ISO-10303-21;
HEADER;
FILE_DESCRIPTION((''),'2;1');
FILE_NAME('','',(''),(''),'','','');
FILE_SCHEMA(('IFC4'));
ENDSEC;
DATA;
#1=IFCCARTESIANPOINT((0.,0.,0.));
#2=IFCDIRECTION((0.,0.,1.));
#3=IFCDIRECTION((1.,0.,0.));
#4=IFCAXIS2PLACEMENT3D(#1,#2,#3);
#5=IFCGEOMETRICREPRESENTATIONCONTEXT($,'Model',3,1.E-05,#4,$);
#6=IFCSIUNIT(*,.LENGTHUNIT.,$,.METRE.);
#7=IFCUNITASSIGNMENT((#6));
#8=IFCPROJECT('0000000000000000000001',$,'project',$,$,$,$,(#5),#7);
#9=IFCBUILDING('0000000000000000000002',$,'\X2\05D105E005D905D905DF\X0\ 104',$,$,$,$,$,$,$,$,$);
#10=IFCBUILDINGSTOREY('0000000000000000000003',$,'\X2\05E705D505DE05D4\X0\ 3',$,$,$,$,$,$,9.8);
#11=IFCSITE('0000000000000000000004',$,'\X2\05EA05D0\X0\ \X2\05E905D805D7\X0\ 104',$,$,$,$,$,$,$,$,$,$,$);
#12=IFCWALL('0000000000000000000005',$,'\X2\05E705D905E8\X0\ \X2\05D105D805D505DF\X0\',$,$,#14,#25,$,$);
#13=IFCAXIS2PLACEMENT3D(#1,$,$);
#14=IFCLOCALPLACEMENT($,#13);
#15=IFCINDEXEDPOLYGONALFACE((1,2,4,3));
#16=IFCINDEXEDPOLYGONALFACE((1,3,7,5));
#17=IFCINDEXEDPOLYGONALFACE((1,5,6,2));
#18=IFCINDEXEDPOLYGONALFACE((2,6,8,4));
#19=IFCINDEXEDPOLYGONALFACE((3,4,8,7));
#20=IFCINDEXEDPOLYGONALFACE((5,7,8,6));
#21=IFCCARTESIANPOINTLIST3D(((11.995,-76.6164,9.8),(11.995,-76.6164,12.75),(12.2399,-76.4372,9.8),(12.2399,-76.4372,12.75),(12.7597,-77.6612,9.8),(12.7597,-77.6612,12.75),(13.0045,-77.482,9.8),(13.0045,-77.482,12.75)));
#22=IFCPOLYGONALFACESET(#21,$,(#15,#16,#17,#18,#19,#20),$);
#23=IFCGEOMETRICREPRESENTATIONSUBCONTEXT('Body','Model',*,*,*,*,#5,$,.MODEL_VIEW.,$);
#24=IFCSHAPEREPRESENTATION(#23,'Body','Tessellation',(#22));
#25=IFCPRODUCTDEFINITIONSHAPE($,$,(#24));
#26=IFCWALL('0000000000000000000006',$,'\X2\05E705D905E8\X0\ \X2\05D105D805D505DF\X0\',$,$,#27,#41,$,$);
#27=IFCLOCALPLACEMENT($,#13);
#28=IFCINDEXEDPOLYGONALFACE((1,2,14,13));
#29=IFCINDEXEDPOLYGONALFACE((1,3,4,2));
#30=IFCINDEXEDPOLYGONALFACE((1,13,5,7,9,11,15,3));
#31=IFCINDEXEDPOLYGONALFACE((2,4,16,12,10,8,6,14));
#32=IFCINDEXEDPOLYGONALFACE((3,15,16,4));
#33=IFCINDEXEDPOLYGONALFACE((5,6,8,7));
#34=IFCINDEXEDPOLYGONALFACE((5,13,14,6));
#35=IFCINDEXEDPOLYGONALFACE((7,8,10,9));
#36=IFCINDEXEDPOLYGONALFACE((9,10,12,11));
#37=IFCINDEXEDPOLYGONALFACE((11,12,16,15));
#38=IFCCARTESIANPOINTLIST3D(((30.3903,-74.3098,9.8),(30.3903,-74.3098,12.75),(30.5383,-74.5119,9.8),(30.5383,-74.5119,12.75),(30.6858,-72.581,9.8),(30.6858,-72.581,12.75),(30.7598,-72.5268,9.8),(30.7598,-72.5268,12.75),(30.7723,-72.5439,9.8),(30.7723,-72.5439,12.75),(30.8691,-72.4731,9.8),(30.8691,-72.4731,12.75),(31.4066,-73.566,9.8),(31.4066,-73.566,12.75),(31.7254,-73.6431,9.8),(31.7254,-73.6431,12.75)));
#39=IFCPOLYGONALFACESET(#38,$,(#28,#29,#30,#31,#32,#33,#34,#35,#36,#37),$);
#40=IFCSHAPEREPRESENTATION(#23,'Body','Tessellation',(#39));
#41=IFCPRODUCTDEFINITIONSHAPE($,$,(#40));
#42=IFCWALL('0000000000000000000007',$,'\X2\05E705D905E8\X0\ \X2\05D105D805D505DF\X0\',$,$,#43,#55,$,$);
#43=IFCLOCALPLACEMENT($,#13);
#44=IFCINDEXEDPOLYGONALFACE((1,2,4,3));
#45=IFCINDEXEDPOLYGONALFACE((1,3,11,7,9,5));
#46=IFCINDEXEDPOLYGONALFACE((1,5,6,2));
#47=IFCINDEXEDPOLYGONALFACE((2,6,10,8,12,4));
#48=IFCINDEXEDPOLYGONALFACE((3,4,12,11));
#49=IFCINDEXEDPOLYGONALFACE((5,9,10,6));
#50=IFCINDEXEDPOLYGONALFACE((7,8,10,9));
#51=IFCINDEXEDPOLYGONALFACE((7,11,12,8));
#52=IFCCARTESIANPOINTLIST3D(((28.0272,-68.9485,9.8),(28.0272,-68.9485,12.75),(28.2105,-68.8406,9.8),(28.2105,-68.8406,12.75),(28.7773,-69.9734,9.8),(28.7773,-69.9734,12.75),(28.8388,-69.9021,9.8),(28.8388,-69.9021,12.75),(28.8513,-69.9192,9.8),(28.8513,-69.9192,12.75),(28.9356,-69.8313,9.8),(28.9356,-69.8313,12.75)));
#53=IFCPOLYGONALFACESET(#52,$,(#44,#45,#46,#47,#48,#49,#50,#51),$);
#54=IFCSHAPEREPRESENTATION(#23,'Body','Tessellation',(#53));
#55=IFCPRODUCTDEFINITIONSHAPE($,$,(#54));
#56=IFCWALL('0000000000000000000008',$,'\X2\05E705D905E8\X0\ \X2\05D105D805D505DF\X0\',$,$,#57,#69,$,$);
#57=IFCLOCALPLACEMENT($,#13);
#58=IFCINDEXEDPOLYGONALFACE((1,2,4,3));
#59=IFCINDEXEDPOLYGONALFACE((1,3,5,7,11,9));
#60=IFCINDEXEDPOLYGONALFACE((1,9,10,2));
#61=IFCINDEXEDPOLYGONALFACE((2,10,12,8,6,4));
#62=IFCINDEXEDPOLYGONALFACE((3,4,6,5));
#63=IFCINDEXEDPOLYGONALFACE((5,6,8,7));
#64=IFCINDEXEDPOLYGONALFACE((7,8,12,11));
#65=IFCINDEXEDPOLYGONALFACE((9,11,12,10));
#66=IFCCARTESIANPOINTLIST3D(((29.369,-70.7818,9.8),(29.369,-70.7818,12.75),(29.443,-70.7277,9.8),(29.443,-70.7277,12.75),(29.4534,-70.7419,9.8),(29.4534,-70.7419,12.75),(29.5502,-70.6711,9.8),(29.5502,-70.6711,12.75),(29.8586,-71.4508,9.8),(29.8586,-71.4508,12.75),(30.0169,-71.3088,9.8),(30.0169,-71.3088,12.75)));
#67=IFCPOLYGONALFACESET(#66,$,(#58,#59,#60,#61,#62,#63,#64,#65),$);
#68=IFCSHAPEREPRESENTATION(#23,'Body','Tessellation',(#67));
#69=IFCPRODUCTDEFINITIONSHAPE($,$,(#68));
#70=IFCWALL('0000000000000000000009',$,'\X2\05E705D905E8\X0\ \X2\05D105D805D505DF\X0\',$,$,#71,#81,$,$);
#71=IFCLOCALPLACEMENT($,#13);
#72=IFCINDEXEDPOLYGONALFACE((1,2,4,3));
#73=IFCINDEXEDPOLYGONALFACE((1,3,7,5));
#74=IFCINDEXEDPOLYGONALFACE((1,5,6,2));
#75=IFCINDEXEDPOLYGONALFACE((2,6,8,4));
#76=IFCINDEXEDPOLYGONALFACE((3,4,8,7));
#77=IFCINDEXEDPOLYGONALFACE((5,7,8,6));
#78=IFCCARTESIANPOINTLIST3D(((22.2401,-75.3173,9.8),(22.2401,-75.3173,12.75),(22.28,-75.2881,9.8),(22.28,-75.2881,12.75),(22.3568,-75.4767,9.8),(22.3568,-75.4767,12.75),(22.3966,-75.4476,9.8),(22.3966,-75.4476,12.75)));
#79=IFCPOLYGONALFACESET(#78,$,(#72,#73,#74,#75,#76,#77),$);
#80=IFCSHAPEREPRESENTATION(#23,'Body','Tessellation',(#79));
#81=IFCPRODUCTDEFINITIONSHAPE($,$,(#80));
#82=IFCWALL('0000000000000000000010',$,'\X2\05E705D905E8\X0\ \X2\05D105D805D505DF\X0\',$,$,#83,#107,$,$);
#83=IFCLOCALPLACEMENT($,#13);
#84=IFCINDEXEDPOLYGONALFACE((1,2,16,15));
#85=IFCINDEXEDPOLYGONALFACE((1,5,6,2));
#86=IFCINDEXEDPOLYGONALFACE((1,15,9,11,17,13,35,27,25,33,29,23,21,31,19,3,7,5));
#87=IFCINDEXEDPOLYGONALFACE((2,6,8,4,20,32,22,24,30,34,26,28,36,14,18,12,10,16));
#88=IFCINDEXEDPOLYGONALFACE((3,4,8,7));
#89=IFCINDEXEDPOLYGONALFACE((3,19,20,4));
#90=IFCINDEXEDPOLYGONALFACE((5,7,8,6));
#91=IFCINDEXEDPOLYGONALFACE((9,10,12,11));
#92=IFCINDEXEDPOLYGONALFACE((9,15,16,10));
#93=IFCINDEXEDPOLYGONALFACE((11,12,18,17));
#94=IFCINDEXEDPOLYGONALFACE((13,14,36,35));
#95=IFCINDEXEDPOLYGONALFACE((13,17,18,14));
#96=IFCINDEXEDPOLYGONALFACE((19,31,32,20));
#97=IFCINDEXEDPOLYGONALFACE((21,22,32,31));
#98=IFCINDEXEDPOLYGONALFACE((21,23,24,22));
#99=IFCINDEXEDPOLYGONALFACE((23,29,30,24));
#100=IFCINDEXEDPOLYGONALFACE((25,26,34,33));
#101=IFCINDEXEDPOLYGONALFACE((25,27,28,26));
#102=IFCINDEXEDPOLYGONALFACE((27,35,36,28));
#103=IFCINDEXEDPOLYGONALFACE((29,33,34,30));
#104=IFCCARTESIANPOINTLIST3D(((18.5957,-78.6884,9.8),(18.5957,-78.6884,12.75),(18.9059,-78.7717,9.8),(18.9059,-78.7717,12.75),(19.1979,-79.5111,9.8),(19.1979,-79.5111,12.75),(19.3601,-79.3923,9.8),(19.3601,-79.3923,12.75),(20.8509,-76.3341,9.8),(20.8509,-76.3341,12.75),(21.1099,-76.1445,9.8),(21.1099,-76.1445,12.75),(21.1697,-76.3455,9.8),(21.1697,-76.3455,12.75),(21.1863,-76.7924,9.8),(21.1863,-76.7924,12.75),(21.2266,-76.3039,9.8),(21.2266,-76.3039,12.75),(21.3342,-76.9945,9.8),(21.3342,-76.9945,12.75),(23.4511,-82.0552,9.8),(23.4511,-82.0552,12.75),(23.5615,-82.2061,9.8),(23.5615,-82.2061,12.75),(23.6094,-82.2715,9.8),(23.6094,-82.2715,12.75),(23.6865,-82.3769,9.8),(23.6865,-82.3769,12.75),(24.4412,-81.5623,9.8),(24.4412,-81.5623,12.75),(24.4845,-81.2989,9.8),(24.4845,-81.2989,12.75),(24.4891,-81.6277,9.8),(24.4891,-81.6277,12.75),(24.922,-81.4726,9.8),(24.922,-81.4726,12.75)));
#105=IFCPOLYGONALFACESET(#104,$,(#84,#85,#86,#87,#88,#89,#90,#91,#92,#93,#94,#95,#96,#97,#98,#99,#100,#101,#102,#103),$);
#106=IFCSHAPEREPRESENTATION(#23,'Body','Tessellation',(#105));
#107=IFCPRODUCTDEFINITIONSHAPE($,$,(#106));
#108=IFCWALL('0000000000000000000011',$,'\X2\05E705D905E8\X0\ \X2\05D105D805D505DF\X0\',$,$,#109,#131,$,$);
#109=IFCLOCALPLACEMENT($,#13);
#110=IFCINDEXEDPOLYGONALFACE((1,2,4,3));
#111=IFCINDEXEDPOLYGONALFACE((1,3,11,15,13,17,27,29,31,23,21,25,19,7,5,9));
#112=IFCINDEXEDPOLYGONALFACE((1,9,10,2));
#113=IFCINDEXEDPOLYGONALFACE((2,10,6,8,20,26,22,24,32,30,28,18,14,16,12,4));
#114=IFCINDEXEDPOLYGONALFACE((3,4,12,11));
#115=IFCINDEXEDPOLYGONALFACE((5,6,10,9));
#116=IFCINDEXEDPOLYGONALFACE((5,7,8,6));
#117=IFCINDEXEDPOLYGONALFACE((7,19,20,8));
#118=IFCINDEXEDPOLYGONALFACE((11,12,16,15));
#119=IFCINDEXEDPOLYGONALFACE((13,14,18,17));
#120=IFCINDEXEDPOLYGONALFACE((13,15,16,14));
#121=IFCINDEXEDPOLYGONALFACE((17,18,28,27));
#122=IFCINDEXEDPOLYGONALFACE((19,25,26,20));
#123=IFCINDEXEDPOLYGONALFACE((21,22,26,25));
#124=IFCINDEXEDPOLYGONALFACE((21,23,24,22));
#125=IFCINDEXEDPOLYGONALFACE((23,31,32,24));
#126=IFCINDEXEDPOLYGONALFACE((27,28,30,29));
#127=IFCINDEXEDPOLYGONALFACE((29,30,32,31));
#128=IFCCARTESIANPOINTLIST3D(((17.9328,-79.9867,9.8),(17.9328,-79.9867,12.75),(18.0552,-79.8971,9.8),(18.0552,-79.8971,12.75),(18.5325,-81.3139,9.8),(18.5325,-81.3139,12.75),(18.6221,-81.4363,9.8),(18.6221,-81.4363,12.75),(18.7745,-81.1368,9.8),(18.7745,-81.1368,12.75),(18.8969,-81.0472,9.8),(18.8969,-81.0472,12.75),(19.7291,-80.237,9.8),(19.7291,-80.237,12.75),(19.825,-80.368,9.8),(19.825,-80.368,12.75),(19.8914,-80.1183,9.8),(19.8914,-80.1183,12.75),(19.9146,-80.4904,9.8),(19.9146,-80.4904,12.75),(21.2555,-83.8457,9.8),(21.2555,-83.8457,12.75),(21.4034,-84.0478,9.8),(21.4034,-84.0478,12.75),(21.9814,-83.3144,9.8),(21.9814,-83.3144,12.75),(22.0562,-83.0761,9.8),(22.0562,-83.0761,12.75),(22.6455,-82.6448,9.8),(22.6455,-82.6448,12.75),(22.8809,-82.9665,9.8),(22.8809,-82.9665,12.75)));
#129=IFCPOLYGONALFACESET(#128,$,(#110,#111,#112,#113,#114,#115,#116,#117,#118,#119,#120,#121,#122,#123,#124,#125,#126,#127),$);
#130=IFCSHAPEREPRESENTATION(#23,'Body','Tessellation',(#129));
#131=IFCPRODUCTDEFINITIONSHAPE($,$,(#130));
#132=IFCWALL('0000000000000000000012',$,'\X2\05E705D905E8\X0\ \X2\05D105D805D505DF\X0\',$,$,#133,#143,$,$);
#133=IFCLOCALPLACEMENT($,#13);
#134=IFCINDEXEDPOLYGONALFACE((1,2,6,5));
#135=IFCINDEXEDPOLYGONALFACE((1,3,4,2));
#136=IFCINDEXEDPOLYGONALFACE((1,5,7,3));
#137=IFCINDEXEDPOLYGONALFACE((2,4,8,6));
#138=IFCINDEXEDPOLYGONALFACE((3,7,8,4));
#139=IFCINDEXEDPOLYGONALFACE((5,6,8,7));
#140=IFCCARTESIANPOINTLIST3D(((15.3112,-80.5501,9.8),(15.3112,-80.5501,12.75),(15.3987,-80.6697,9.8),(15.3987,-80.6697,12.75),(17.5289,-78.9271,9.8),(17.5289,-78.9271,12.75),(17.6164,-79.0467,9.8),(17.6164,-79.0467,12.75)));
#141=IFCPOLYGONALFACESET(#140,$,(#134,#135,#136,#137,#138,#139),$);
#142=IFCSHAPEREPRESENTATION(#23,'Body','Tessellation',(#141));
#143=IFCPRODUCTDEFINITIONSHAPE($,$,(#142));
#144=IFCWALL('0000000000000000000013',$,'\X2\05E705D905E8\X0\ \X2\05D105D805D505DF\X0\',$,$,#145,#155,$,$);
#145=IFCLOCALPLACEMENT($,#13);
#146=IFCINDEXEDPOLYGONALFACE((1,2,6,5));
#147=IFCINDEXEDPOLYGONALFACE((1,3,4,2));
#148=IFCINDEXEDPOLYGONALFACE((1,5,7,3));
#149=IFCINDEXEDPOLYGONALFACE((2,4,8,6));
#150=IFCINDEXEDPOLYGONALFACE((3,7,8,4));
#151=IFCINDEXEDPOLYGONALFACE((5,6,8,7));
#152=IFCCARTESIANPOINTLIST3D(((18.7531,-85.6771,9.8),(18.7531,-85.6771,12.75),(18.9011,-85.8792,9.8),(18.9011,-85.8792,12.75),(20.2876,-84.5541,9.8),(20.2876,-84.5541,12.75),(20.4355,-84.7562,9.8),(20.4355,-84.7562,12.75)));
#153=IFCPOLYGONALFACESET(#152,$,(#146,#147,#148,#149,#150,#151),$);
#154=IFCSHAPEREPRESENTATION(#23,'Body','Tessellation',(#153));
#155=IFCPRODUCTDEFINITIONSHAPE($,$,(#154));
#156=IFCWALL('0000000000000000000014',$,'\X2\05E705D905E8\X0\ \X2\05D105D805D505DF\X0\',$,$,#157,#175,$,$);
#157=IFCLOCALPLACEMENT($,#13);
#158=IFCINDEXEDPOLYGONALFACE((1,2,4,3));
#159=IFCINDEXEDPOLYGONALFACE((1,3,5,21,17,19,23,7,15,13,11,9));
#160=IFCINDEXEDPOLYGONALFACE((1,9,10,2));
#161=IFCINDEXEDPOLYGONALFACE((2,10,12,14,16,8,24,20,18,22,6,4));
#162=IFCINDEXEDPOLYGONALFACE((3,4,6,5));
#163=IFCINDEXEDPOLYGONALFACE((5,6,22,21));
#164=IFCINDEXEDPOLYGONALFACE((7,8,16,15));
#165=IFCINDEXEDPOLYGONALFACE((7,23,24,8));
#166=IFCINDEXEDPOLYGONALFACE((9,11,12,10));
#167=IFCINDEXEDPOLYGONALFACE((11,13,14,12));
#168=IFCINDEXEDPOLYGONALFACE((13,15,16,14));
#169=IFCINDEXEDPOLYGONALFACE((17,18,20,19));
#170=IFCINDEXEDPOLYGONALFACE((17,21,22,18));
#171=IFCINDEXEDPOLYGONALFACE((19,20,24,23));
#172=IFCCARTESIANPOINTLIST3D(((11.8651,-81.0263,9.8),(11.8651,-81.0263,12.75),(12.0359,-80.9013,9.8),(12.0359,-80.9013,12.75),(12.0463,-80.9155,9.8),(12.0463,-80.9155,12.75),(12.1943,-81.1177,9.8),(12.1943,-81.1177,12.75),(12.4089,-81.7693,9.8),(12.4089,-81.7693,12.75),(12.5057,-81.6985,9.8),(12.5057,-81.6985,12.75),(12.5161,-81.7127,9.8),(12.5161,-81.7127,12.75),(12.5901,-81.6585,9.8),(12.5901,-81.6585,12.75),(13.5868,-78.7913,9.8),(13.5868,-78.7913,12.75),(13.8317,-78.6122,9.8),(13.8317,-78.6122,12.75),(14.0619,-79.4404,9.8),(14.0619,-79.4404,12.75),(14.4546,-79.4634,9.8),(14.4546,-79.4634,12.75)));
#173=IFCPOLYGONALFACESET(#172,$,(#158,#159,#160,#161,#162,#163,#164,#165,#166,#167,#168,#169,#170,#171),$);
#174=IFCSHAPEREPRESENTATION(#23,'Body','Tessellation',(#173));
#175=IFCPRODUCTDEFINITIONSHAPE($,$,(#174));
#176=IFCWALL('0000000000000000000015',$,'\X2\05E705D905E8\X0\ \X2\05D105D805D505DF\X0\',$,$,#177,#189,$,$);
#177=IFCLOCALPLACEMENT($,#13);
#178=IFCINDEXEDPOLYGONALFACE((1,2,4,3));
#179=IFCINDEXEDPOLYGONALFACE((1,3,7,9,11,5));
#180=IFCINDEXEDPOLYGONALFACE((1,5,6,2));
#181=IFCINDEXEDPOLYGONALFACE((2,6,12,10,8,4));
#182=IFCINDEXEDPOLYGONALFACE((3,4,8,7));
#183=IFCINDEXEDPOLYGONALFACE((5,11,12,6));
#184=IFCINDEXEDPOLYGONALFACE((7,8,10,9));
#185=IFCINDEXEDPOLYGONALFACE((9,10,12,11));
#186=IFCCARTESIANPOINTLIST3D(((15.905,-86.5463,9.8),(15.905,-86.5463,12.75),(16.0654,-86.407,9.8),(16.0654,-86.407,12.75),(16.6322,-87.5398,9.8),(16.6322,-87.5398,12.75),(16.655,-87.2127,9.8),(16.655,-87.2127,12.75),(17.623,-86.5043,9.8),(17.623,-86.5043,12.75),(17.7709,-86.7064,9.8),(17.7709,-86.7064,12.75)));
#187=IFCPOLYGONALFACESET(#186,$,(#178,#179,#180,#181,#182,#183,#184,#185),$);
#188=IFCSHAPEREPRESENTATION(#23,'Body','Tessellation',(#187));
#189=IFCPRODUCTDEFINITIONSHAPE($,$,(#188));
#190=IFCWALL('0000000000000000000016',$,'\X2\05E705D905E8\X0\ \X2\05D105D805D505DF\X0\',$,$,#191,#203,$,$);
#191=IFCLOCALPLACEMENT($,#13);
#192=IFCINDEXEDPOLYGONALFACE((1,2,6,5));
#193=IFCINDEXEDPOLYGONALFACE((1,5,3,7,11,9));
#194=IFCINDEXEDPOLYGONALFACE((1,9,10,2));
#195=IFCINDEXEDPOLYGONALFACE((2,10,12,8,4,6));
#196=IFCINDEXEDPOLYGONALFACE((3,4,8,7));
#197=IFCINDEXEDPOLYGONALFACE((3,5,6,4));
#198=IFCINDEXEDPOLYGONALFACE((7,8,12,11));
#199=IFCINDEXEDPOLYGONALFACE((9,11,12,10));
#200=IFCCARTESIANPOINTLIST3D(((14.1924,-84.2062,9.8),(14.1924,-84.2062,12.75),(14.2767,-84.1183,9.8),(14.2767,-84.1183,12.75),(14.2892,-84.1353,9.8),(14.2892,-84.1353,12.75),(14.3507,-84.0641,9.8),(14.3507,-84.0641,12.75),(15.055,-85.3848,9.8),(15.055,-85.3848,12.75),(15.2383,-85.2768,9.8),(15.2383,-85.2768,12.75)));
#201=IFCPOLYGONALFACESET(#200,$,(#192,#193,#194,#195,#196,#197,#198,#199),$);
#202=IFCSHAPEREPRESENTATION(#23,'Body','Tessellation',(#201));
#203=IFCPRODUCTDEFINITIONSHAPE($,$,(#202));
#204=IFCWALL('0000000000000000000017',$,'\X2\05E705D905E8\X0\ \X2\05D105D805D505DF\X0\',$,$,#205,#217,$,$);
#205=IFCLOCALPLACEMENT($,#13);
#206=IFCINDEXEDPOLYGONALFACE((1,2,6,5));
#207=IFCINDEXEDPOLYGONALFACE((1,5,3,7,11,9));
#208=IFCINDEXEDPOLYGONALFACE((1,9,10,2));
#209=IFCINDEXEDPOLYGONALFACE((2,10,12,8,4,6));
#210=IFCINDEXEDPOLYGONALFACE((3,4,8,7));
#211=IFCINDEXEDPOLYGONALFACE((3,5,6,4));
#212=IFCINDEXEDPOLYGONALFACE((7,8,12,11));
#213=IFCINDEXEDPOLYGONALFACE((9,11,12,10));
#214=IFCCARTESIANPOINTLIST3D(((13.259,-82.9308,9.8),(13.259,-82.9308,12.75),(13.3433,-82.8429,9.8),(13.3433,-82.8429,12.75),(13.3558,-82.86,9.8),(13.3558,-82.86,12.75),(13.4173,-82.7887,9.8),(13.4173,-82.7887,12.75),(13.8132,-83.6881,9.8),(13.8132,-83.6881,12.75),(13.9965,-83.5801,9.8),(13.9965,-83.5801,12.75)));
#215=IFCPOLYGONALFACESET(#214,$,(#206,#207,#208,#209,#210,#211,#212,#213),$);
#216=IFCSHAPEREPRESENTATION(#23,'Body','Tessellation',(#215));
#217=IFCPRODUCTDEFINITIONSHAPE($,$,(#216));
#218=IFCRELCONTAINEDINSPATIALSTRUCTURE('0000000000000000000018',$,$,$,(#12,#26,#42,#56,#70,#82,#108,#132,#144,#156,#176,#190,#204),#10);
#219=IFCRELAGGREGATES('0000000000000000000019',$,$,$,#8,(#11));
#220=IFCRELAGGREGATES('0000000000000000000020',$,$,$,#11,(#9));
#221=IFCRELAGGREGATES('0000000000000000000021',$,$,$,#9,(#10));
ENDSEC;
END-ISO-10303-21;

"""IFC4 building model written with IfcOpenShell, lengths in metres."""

from ifc_helpers import new_model, si_unit, frame, origin_with_axes, context, subcontext, project, spatial, polyline, outline, extrude, element, save


model = new_model("IFC4")

# Units and contexts
model_context = context("Model", 3, precision=1e-05, world=origin_with_axes())
body_context = subcontext(model_context, "Body", "Model", "MODEL_VIEW")
ifc_project = project(units=[si_unit("LENGTHUNIT", "METRE")], contexts=[model_context])

# Site, building, storey
site = spatial("IfcSite", under=ifc_project, Name="תא שטח 104")
building = spatial("IfcBuilding", under=site, Name="בניין 104")
storey = spatial("IfcBuildingStorey", under=building, Name="קומה 3", Elevation=9.8)

# Walls
element("IfcWall", 1, inside=storey, Name="קיר בטון", context=body_context, shape_type="SweptSolid", body=[
    extrude(outline(polyline([(12.2399, -76.4372), (11.995, -76.6164), (12.7597, -77.6612), (13.0045, -77.482), (12.2399, -76.4372)])), frame((0.0, 0.0, 9.8)), (0.0, 0.0, 1.0), 2.95),
])
element("IfcWall", 2, inside=storey, Name="קיר בטון", context=body_context, shape_type="SweptSolid", body=[
    extrude(outline(polyline([(31.4066, -73.566), (30.3903, -74.3098), (30.5383, -74.5119), (31.7254, -73.6431), (30.8691, -72.4731), (30.7723, -72.5439), (30.7598, -72.5268), (30.6858, -72.581), (31.4066, -73.566)])), frame((0.0, 0.0, 9.8)), (0.0, 0.0, 1.0), 2.95),
])
element("IfcWall", 3, inside=storey, Name="קיר בטון", context=body_context, shape_type="SweptSolid", body=[
    extrude(outline(polyline([(28.0272, -68.9485), (28.7773, -69.9734), (28.8513, -69.9192), (28.8388, -69.9021), (28.9356, -69.8313), (28.2105, -68.8406), (28.0272, -68.9485)])), frame((0.0, 0.0, 9.8)), (0.0, 0.0, 1.0), 2.95),
])
element("IfcWall", 4, inside=storey, Name="קיר בטון", context=body_context, shape_type="SweptSolid", body=[
    extrude(outline(polyline([(29.443, -70.7277), (29.369, -70.7818), (29.8586, -71.4508), (30.0169, -71.3088), (29.5502, -70.6711), (29.4534, -70.7419), (29.443, -70.7277)])), frame((0.0, 0.0, 9.8)), (0.0, 0.0, 1.0), 2.95),
])
element("IfcWall", 5, inside=storey, Name="קיר בטון", context=body_context, shape_type="SweptSolid", body=[
    extrude(outline(polyline([(22.3966, -75.4476), (22.28, -75.2881), (22.2401, -75.3173), (22.3568, -75.4767), (22.3966, -75.4476)])), frame((0.0, 0.0, 9.8)), (0.0, 0.0, 1.0), 2.95),
])
element("IfcWall", 6, inside=storey, Name="קיר בטון", context=body_context, shape_type="SweptSolid", body=[
    extrude(outline(polyline([(21.1863, -76.7924), (18.5957, -78.6884), (19.1979, -79.5111), (19.3601, -79.3923), (18.9059, -78.7717), (21.3342, -76.9945), (24.4845, -81.2989), (23.4511, -82.0552), (23.5615, -82.2061), (24.4412, -81.5623), (24.4891, -81.6277), (23.6094, -82.2715), (23.6865, -82.3769), (24.922, -81.4726), (21.1697, -76.3455), (21.2266, -76.3039), (21.1099, -76.1445), (20.8509, -76.3341), (21.1863, -76.7924)])), frame((0.0, 0.0, 9.8)), (0.0, 0.0, 1.0), 2.95),
])
element("IfcWall", 7, inside=storey, Name="קיר בטון", context=body_context, shape_type="SweptSolid", body=[
    extrude(outline(polyline([(18.8969, -81.0472), (18.0552, -79.8971), (17.9328, -79.9867), (18.7745, -81.1368), (18.5325, -81.3139), (18.6221, -81.4363), (19.9146, -80.4904), (21.9814, -83.3144), (21.2555, -83.8457), (21.4034, -84.0478), (22.8809, -82.9665), (22.6455, -82.6448), (22.0562, -83.0761), (19.8914, -80.1183), (19.7291, -80.237), (19.825, -80.368), (18.8969, -81.0472)])), frame((0.0, 0.0, 9.8)), (0.0, 0.0, 1.0), 2.95),
])
element("IfcWall", 8, inside=storey, Name="קיר בטון", context=body_context, shape_type="SweptSolid", body=[
    extrude(outline(polyline([(17.5289, -78.9271), (15.3112, -80.5501), (15.3987, -80.6697), (17.6164, -79.0467), (17.5289, -78.9271)])), frame((0.0, 0.0, 9.8)), (0.0, 0.0, 1.0), 2.95),
])
element("IfcWall", 9, inside=storey, Name="קיר בטון", context=body_context, shape_type="SweptSolid", body=[
    extrude(outline(polyline([(20.4355, -84.7562), (20.2876, -84.5541), (18.7531, -85.6771), (18.9011, -85.8792), (20.4355, -84.7562)])), frame((0.0, 0.0, 9.8)), (0.0, 0.0, 1.0), 2.95),
])
element("IfcWall", 10, inside=storey, Name="קיר בטון", context=body_context, shape_type="SweptSolid", body=[
    extrude(outline(polyline([(12.0463, -80.9155), (12.0359, -80.9013), (11.8651, -81.0263), (12.4089, -81.7693), (12.5057, -81.6985), (12.5161, -81.7127), (12.5901, -81.6585), (12.1943, -81.1177), (14.4546, -79.4634), (13.8317, -78.6122), (13.5868, -78.7913), (14.0619, -79.4404), (12.0463, -80.9155)])), frame((0.0, 0.0, 9.8)), (0.0, 0.0, 1.0), 2.95),
])
element("IfcWall", 11, inside=storey, Name="קיר בטון", context=body_context, shape_type="SweptSolid", body=[
    extrude(outline(polyline([(15.905, -86.5463), (16.6322, -87.5398), (17.7709, -86.7064), (17.623, -86.5043), (16.655, -87.2127), (16.0654, -86.407), (15.905, -86.5463)])), frame((0.0, 0.0, 9.8)), (0.0, 0.0, 1.0), 2.95),
])
element("IfcWall", 12, inside=storey, Name="קיר בטון", context=body_context, shape_type="SweptSolid", body=[
    extrude(outline(polyline([(14.2892, -84.1353), (14.1924, -84.2062), (15.055, -85.3848), (15.2383, -85.2768), (14.3507, -84.0641), (14.2767, -84.1183), (14.2892, -84.1353)])), frame((0.0, 0.0, 9.8)), (0.0, 0.0, 1.0), 2.95),
])
element("IfcWall", 13, inside=storey, Name="קיר בטון", context=body_context, shape_type="SweptSolid", body=[
    extrude(outline(polyline([(13.3558, -82.86), (13.259, -82.9308), (13.8132, -83.6881), (13.9965, -83.5801), (13.4173, -82.7887), (13.3433, -82.8429), (13.3558, -82.86)])), frame((0.0, 0.0, 9.8)), (0.0, 0.0, 1.0), 2.95),
])

save(model, "model.ifc")
